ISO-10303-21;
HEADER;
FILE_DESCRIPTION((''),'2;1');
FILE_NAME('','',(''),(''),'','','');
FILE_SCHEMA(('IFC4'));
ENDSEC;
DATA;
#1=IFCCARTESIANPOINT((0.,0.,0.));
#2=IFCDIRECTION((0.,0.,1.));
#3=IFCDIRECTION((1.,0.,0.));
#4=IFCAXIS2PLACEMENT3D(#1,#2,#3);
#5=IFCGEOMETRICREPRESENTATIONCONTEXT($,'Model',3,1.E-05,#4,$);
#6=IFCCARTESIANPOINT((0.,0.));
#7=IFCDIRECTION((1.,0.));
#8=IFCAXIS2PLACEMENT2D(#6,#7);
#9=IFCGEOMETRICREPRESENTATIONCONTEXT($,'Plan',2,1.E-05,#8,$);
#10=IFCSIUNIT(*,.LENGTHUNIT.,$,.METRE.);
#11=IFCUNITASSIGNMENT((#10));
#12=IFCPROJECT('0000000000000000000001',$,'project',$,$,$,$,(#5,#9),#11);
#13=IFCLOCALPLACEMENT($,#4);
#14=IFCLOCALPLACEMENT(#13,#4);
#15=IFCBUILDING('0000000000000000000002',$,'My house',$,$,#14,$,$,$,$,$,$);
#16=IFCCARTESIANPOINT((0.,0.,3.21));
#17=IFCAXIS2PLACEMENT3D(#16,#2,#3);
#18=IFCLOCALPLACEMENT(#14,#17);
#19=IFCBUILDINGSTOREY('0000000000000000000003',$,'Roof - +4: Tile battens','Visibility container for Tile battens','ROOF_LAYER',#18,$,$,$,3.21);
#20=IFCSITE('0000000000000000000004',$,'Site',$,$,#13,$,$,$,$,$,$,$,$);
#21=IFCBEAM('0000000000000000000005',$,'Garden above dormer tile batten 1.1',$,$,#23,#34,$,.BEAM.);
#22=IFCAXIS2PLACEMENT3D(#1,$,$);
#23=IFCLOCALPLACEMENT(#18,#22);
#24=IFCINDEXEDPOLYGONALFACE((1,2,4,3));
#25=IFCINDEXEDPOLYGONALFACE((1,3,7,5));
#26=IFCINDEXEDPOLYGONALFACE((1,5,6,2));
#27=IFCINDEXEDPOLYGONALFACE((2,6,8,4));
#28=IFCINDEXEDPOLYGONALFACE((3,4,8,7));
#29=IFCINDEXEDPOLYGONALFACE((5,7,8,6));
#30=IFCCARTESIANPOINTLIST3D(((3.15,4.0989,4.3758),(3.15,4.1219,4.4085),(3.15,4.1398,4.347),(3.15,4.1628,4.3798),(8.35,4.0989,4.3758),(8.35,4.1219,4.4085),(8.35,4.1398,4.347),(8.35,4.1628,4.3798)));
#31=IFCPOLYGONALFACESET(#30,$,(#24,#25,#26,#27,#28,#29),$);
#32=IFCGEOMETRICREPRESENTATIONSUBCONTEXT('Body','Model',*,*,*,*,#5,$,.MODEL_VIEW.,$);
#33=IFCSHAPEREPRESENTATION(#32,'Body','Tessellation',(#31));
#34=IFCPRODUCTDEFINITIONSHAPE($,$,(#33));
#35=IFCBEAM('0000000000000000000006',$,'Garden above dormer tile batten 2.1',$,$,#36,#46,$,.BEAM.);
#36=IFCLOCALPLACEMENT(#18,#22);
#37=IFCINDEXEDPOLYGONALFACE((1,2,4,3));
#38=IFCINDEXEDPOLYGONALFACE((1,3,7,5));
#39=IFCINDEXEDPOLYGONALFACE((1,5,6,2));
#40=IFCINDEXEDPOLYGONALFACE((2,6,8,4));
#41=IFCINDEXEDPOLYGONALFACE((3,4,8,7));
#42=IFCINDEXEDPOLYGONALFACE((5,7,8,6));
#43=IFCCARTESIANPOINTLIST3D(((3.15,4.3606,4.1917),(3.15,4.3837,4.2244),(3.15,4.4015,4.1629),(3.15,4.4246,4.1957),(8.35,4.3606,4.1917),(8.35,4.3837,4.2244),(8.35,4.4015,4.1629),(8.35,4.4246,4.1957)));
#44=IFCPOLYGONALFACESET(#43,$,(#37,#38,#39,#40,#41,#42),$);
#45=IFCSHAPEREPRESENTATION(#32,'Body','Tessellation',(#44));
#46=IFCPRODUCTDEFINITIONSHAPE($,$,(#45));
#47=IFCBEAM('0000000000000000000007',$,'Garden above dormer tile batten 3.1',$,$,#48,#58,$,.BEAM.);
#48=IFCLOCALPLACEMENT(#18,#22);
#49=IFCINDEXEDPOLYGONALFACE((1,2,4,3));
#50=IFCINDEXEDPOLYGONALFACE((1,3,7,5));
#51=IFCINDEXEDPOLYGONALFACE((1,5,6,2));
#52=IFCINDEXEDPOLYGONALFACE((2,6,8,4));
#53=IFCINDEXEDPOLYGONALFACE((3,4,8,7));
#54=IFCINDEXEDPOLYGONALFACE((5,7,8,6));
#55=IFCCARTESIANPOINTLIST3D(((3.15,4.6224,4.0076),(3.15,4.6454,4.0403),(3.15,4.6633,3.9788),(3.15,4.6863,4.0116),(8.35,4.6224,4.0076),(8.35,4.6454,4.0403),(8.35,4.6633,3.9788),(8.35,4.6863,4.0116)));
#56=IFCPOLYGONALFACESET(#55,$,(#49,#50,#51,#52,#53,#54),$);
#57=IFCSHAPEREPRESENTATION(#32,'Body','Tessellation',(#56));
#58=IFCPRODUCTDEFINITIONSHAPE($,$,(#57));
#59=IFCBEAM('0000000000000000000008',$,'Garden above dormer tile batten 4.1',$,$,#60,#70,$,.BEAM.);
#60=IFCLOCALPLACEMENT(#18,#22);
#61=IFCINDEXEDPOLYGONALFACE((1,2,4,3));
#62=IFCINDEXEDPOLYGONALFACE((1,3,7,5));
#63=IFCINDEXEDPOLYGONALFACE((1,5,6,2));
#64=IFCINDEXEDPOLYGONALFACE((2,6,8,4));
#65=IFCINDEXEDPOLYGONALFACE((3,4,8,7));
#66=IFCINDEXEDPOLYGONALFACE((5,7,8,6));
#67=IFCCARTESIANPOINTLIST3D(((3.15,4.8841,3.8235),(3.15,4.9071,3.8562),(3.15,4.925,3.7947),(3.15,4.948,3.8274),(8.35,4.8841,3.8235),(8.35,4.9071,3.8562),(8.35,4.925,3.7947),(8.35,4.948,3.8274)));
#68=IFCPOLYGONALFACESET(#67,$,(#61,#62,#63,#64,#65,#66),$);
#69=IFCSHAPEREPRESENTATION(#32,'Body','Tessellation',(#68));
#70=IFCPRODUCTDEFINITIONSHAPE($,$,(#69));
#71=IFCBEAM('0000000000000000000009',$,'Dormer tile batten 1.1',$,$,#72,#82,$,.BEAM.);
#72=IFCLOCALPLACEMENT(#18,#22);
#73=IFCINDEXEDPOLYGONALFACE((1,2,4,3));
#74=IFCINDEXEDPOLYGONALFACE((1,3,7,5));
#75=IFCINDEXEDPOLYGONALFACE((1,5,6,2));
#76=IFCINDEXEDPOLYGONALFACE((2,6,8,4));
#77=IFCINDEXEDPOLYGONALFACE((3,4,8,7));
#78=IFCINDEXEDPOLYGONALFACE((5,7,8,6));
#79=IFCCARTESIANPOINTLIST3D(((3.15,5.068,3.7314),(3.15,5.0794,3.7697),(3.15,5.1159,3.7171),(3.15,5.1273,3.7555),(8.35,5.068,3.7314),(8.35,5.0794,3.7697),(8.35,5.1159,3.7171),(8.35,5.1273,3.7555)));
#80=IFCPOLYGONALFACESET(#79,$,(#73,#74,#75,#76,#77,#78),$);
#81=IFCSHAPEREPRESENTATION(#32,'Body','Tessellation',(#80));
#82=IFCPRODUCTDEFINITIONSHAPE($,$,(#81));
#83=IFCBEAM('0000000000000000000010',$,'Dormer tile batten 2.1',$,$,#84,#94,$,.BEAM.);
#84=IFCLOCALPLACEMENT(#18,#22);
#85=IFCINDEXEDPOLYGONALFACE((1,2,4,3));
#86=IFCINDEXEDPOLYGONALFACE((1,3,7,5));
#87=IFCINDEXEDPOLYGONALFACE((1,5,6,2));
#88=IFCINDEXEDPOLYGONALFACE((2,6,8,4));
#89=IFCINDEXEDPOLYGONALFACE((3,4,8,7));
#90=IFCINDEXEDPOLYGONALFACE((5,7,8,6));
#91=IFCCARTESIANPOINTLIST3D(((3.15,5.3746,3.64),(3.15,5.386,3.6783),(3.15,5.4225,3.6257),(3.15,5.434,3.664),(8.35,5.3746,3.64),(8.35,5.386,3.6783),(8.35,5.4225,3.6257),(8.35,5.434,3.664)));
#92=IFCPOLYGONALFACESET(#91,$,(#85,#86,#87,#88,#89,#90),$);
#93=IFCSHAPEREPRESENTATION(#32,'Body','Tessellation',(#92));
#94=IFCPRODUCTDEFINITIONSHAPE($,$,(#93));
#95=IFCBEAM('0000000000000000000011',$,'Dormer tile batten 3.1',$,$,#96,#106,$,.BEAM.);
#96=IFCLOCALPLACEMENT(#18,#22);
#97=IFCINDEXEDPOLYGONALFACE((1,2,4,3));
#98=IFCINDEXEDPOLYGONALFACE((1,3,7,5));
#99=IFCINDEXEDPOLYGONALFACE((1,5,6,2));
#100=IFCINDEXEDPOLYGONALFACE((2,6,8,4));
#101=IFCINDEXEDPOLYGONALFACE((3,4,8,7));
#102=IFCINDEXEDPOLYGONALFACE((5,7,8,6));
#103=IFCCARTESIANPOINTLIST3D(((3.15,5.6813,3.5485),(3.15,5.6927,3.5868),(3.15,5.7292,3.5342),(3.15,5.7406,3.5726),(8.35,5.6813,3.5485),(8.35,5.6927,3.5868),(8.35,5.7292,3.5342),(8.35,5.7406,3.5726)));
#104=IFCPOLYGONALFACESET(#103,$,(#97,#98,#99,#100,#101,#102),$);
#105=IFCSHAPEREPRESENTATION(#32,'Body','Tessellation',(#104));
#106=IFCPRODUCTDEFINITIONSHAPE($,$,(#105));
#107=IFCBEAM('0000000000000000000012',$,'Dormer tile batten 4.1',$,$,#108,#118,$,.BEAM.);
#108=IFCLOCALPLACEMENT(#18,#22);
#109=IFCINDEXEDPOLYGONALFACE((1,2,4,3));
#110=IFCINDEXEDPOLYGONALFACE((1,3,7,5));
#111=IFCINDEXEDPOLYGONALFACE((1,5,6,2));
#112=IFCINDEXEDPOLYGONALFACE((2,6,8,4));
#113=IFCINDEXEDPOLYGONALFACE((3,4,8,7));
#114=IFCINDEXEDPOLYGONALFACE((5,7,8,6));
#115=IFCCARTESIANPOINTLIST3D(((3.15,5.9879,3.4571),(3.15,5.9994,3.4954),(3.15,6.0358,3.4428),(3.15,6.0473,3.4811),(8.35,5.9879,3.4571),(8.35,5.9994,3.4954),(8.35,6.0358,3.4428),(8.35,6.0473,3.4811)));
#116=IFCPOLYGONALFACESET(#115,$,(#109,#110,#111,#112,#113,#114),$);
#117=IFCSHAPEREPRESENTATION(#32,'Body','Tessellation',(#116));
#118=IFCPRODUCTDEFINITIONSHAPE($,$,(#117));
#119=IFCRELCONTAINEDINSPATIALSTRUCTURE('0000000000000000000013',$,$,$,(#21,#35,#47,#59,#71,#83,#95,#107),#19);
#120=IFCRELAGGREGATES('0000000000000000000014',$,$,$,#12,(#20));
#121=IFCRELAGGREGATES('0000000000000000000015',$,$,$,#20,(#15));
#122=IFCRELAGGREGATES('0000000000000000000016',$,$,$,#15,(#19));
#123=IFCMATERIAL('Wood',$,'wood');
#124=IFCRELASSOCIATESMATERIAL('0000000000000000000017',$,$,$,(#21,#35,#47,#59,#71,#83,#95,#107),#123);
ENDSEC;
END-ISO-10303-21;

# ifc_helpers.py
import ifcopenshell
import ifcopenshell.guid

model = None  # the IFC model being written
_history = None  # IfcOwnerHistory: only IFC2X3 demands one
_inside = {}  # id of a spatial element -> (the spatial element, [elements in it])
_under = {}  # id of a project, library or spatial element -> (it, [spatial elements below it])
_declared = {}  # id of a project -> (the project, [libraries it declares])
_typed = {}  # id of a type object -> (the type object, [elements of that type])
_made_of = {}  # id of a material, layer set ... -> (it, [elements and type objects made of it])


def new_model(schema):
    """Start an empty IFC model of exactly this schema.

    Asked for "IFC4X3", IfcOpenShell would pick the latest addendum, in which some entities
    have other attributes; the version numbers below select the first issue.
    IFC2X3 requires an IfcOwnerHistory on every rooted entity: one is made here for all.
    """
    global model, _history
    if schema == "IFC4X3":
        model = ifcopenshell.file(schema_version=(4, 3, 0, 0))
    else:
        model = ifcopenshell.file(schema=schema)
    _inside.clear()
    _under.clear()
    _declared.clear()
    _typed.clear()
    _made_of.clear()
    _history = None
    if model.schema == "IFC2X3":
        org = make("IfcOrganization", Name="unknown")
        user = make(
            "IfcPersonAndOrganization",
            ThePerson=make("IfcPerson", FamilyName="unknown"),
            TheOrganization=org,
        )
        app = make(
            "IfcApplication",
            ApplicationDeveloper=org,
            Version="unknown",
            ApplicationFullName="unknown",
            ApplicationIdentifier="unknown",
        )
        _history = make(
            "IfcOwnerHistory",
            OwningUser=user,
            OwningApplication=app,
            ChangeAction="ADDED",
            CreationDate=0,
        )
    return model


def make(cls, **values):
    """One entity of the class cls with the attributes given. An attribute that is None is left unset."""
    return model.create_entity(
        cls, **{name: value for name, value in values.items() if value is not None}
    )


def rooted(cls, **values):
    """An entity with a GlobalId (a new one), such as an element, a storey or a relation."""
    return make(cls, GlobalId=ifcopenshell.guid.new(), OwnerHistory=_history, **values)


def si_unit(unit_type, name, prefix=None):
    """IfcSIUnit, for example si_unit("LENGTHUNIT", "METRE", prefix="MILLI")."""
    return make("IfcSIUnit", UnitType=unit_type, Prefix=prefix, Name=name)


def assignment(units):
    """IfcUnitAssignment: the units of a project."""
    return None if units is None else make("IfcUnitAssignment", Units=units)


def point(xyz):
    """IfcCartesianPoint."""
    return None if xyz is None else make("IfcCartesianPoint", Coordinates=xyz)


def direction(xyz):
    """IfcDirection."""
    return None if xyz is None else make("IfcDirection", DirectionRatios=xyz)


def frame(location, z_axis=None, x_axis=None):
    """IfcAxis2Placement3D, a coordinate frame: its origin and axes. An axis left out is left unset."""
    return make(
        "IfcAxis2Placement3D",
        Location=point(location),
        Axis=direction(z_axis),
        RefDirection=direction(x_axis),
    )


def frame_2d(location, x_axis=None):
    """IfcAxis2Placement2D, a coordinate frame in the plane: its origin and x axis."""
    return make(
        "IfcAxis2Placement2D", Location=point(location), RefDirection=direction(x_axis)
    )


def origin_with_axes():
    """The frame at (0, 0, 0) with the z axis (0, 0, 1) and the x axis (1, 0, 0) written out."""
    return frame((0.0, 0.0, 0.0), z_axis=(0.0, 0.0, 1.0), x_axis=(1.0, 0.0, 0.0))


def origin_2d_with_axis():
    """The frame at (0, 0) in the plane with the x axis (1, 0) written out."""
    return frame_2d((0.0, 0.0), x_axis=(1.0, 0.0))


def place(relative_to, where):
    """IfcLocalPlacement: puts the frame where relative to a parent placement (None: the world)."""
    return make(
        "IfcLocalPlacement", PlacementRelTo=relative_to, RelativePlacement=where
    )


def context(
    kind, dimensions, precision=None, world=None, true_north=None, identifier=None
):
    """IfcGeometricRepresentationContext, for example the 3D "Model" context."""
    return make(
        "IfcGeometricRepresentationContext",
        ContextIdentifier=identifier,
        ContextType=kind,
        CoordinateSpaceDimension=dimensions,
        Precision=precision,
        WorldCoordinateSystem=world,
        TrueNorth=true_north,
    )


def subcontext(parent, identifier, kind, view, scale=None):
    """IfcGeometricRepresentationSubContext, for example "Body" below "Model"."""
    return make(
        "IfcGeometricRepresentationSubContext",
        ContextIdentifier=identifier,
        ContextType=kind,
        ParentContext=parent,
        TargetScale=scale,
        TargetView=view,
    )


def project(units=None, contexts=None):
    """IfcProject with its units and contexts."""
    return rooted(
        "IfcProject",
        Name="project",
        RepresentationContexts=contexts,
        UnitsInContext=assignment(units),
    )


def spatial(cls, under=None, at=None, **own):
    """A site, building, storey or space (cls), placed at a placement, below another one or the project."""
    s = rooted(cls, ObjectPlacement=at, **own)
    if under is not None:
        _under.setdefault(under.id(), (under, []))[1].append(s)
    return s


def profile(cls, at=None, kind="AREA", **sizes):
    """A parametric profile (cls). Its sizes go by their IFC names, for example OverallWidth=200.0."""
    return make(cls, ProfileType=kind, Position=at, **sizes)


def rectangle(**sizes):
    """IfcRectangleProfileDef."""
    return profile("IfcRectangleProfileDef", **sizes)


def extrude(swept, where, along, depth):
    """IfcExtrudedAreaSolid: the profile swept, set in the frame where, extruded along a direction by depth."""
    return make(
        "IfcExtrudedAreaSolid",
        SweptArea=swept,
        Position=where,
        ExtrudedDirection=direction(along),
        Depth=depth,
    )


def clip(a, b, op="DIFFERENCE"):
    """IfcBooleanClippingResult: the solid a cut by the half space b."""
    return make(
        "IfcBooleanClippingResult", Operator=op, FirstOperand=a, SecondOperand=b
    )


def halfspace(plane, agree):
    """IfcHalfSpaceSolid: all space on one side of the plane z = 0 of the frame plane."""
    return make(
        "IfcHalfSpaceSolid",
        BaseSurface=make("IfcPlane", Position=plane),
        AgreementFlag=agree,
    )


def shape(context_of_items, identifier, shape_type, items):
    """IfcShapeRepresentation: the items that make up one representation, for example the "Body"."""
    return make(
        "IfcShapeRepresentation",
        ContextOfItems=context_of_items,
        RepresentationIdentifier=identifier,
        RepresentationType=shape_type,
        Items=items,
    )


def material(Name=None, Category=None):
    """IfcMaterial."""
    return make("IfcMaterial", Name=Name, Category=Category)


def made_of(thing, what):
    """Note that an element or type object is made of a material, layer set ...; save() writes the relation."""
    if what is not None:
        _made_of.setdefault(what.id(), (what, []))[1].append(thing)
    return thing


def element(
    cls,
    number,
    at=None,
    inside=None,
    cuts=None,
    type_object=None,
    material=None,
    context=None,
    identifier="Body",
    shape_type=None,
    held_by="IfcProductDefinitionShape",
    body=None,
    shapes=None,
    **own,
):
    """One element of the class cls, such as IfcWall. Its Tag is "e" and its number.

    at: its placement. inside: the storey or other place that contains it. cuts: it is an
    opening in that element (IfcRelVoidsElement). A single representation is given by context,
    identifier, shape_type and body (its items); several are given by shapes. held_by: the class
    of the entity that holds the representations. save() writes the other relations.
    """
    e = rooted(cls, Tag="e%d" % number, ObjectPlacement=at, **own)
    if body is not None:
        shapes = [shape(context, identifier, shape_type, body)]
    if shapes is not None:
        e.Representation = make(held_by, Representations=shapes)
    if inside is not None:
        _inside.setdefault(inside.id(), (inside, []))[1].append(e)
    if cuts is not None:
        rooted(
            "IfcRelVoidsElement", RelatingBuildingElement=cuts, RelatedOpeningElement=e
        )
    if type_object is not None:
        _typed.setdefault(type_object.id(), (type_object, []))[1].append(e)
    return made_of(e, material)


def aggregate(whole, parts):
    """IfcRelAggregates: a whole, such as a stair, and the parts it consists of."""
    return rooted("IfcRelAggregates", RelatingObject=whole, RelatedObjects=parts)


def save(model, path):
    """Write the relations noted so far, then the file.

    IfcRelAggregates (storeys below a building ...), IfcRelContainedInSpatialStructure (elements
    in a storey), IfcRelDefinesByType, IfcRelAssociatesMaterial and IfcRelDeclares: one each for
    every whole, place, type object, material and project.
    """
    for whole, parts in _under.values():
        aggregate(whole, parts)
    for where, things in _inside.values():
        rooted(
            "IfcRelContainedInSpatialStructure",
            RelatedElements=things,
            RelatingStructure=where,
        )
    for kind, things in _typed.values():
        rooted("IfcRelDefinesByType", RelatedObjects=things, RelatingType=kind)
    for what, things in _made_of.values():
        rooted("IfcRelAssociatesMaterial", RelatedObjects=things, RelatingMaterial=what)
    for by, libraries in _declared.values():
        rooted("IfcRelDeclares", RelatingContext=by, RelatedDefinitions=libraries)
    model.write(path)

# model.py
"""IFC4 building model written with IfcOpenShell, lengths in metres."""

from ifc_helpers import new_model, si_unit, frame, origin_with_axes, origin_2d_with_axis, place, context, subcontext, project, spatial, rectangle, extrude, clip, halfspace, material, element, save


model = new_model("IFC4")

# Units and contexts
model_context = context("Model", 3, precision=1e-05, world=origin_with_axes())
plan_context = context("Plan", 2, precision=1e-05, world=origin_2d_with_axis())
body_context = subcontext(model_context, "Body", "Model", "MODEL_VIEW")
ifc_project = project(units=[si_unit("LENGTHUNIT", "METRE")], contexts=[model_context, plan_context])

# Site, building, storey
site_placement = place(None, origin_with_axes())
site = spatial("IfcSite", under=ifc_project, at=site_placement, Name="Site")
building_placement = place(site_placement, origin_with_axes())
building = spatial("IfcBuilding", under=site, at=building_placement, Name="My house")
storey_placement = place(building_placement, frame((0.0, 0.0, 3.21), z_axis=(0.0, 0.0, 1.0), x_axis=(1.0, 0.0, 0.0)))
storey = spatial("IfcBuildingStorey", under=building, at=storey_placement, Name="Roof - +4: Tile battens", Description="Visibility container for Tile battens", ObjectType="ROOF_LAYER", Elevation=3.21)

# Beams
ifc_material = material(Name="Wood", Category="wood")
beam_1_placement = place(storey_placement, frame((3.15, 4.1309, 4.3778), z_axis=(0.0, 0.575329, 0.817922), x_axis=(1.0, 0.0, 0.0)))
element("IfcBeam", 1, at=beam_1_placement, inside=storey, material=ifc_material, Name="Garden above dormer tile batten 1.1", PredefinedType="BEAM", context=body_context, shape_type="Clipping", body=[
    clip(clip(extrude(rectangle(XDim=0.05, YDim=0.04), frame((0.0, 0.0, 0.0), z_axis=(1.0, 0.0, 0.0), x_axis=(0.0, 1.0, 0.0)), (0.0, 0.0, 1.0), 5.2), halfspace(frame((-3.15, 4.2584, -6.2815), z_axis=(0.0, -0.817922, -0.575329), x_axis=(-1.0, 0.0, 0.0)), False)), halfspace(frame((-3.15, 7.8573, -3.7501), z_axis=(0.0, 0.817922, 0.575329), x_axis=(1.0, 0.0, 0.0)), False)),
])
beam_2_placement = place(storey_placement, frame((3.15, 4.3926, 4.1937), z_axis=(0.0, 0.575329, 0.817922), x_axis=(1.0, 0.0, 0.0)))
element("IfcBeam", 2, at=beam_2_placement, inside=storey, material=ifc_material, Name="Garden above dormer tile batten 2.1", PredefinedType="BEAM", context=body_context, shape_type="Clipping", body=[
    clip(clip(extrude(rectangle(XDim=0.05, YDim=0.04), frame((0.0, 0.0, 0.0), z_axis=(1.0, 0.0, 0.0), x_axis=(0.0, 1.0, 0.0)), (0.0, 0.0, 1.0), 5.2), halfspace(frame((-3.15, 3.9384, -6.2815), z_axis=(0.0, -0.817922, -0.575329), x_axis=(-1.0, 0.0, 0.0)), False)), halfspace(frame((-3.15, 7.5373, -3.7501), z_axis=(0.0, 0.817922, 0.575329), x_axis=(1.0, 0.0, 0.0)), False)),
])
beam_3_placement = place(storey_placement, frame((3.15, 4.6543, 4.0096), z_axis=(0.0, 0.575329, 0.817922), x_axis=(1.0, 0.0, 0.0)))
element("IfcBeam", 3, at=beam_3_placement, inside=storey, material=ifc_material, Name="Garden above dormer tile batten 3.1", PredefinedType="BEAM", context=body_context, shape_type="Clipping", body=[
    clip(clip(extrude(rectangle(XDim=0.05, YDim=0.04), frame((0.0, 0.0, 0.0), z_axis=(1.0, 0.0, 0.0), x_axis=(0.0, 1.0, 0.0)), (0.0, 0.0, 1.0), 5.2), halfspace(frame((-3.15, 3.6184, -6.2815), z_axis=(0.0, -0.817922, -0.575329), x_axis=(-1.0, 0.0, 0.0)), False)), halfspace(frame((-3.15, 7.2173, -3.7501), z_axis=(0.0, 0.817922, 0.575329), x_axis=(1.0, 0.0, 0.0)), False)),
])
beam_4_placement = place(storey_placement, frame((3.15, 4.9161, 3.8255), z_axis=(0.0, 0.575329, 0.817922), x_axis=(1.0, 0.0, 0.0)))
element("IfcBeam", 4, at=beam_4_placement, inside=storey, material=ifc_material, Name="Garden above dormer tile batten 4.1", PredefinedType="BEAM", context=body_context, shape_type="Clipping", body=[
    clip(clip(extrude(rectangle(XDim=0.05, YDim=0.04), frame((0.0, 0.0, 0.0), z_axis=(1.0, 0.0, 0.0), x_axis=(0.0, 1.0, 0.0)), (0.0, 0.0, 1.0), 5.2), halfspace(frame((-3.15, 3.2984, -6.2815), z_axis=(0.0, -0.817922, -0.575329), x_axis=(-1.0, 0.0, 0.0)), False)), halfspace(frame((-3.15, 6.8973, -3.7501), z_axis=(0.0, 0.817922, 0.575329), x_axis=(1.0, 0.0, 0.0)), False)),
])
beam_5_placement = place(storey_placement, frame((3.15, 5.0976, 3.7434), z_axis=(0.0, 0.28578, 0.958295), x_axis=(1.0, 0.0, 0.0)))
element("IfcBeam", 5, at=beam_5_placement, inside=storey, material=ifc_material, Name="Dormer tile batten 1.1", PredefinedType="BEAM", context=body_context, shape_type="Clipping", body=[
    clip(clip(extrude(rectangle(XDim=0.05, YDim=0.04), frame((0.0, 0.0, 0.0), z_axis=(1.0, 0.0, 0.0), x_axis=(0.0, 1.0, 0.0)), (0.0, 0.0, 1.0), 5.2), halfspace(frame((-3.15, 0.9353, -6.9771), z_axis=(0.0, -0.958295, -0.28578), x_axis=(-1.0, 0.0, 0.0)), False)), halfspace(frame((-3.15, 5.1518, -5.7197), z_axis=(0.0, 0.958295, 0.28578), x_axis=(1.0, 0.0, 0.0)), False)),
])
beam_6_placement = place(storey_placement, frame((3.15, 5.4043, 3.652), z_axis=(0.0, 0.28578, 0.958295), x_axis=(1.0, 0.0, 0.0)))
element("IfcBeam", 6, at=beam_6_placement, inside=storey, material=ifc_material, Name="Dormer tile batten 2.1", PredefinedType="BEAM", context=body_context, shape_type="Clipping", body=[
    clip(clip(extrude(rectangle(XDim=0.05, YDim=0.04), frame((0.0, 0.0, 0.0), z_axis=(1.0, 0.0, 0.0), x_axis=(0.0, 1.0, 0.0)), (0.0, 0.0, 1.0), 5.2), halfspace(frame((-3.15, 0.6153, -6.9771), z_axis=(0.0, -0.958295, -0.28578), x_axis=(-1.0, 0.0, 0.0)), False)), halfspace(frame((-3.15, 4.8318, -5.7197), z_axis=(0.0, 0.958295, 0.28578), x_axis=(1.0, 0.0, 0.0)), False)),
])
beam_7_placement = place(storey_placement, frame((3.15, 5.7109, 3.5605), z_axis=(0.0, 0.28578, 0.958295), x_axis=(1.0, 0.0, 0.0)))
element("IfcBeam", 7, at=beam_7_placement, inside=storey, material=ifc_material, Name="Dormer tile batten 3.1", PredefinedType="BEAM", context=body_context, shape_type="Clipping", body=[
    clip(clip(extrude(rectangle(XDim=0.05, YDim=0.04), frame((0.0, 0.0, 0.0), z_axis=(1.0, 0.0, 0.0), x_axis=(0.0, 1.0, 0.0)), (0.0, 0.0, 1.0), 5.2), halfspace(frame((-3.15, 0.2953, -6.9771), z_axis=(0.0, -0.958295, -0.28578), x_axis=(-1.0, 0.0, 0.0)), False)), halfspace(frame((-3.15, 4.5118, -5.7197), z_axis=(0.0, 0.958295, 0.28578), x_axis=(1.0, 0.0, 0.0)), False)),
])
beam_8_placement = place(storey_placement, frame((3.15, 6.0176, 3.4691), z_axis=(0.0, 0.28578, 0.958295), x_axis=(1.0, 0.0, 0.0)))
element("IfcBeam", 8, at=beam_8_placement, inside=storey, material=ifc_material, Name="Dormer tile batten 4.1", PredefinedType="BEAM", context=body_context, shape_type="Clipping", body=[
    clip(clip(extrude(rectangle(XDim=0.05, YDim=0.04), frame((0.0, 0.0, 0.0), z_axis=(1.0, 0.0, 0.0), x_axis=(0.0, 1.0, 0.0)), (0.0, 0.0, 1.0), 5.2), halfspace(frame((-3.15, -0.0247, -6.9771), z_axis=(0.0, -0.958295, -0.28578), x_axis=(-1.0, 0.0, 0.0)), False)), halfspace(frame((-3.15, 4.1918, -5.7197), z_axis=(0.0, 0.958295, 0.28578), x_axis=(1.0, 0.0, 0.0)), False)),
])

save(model, "model.ifc")
